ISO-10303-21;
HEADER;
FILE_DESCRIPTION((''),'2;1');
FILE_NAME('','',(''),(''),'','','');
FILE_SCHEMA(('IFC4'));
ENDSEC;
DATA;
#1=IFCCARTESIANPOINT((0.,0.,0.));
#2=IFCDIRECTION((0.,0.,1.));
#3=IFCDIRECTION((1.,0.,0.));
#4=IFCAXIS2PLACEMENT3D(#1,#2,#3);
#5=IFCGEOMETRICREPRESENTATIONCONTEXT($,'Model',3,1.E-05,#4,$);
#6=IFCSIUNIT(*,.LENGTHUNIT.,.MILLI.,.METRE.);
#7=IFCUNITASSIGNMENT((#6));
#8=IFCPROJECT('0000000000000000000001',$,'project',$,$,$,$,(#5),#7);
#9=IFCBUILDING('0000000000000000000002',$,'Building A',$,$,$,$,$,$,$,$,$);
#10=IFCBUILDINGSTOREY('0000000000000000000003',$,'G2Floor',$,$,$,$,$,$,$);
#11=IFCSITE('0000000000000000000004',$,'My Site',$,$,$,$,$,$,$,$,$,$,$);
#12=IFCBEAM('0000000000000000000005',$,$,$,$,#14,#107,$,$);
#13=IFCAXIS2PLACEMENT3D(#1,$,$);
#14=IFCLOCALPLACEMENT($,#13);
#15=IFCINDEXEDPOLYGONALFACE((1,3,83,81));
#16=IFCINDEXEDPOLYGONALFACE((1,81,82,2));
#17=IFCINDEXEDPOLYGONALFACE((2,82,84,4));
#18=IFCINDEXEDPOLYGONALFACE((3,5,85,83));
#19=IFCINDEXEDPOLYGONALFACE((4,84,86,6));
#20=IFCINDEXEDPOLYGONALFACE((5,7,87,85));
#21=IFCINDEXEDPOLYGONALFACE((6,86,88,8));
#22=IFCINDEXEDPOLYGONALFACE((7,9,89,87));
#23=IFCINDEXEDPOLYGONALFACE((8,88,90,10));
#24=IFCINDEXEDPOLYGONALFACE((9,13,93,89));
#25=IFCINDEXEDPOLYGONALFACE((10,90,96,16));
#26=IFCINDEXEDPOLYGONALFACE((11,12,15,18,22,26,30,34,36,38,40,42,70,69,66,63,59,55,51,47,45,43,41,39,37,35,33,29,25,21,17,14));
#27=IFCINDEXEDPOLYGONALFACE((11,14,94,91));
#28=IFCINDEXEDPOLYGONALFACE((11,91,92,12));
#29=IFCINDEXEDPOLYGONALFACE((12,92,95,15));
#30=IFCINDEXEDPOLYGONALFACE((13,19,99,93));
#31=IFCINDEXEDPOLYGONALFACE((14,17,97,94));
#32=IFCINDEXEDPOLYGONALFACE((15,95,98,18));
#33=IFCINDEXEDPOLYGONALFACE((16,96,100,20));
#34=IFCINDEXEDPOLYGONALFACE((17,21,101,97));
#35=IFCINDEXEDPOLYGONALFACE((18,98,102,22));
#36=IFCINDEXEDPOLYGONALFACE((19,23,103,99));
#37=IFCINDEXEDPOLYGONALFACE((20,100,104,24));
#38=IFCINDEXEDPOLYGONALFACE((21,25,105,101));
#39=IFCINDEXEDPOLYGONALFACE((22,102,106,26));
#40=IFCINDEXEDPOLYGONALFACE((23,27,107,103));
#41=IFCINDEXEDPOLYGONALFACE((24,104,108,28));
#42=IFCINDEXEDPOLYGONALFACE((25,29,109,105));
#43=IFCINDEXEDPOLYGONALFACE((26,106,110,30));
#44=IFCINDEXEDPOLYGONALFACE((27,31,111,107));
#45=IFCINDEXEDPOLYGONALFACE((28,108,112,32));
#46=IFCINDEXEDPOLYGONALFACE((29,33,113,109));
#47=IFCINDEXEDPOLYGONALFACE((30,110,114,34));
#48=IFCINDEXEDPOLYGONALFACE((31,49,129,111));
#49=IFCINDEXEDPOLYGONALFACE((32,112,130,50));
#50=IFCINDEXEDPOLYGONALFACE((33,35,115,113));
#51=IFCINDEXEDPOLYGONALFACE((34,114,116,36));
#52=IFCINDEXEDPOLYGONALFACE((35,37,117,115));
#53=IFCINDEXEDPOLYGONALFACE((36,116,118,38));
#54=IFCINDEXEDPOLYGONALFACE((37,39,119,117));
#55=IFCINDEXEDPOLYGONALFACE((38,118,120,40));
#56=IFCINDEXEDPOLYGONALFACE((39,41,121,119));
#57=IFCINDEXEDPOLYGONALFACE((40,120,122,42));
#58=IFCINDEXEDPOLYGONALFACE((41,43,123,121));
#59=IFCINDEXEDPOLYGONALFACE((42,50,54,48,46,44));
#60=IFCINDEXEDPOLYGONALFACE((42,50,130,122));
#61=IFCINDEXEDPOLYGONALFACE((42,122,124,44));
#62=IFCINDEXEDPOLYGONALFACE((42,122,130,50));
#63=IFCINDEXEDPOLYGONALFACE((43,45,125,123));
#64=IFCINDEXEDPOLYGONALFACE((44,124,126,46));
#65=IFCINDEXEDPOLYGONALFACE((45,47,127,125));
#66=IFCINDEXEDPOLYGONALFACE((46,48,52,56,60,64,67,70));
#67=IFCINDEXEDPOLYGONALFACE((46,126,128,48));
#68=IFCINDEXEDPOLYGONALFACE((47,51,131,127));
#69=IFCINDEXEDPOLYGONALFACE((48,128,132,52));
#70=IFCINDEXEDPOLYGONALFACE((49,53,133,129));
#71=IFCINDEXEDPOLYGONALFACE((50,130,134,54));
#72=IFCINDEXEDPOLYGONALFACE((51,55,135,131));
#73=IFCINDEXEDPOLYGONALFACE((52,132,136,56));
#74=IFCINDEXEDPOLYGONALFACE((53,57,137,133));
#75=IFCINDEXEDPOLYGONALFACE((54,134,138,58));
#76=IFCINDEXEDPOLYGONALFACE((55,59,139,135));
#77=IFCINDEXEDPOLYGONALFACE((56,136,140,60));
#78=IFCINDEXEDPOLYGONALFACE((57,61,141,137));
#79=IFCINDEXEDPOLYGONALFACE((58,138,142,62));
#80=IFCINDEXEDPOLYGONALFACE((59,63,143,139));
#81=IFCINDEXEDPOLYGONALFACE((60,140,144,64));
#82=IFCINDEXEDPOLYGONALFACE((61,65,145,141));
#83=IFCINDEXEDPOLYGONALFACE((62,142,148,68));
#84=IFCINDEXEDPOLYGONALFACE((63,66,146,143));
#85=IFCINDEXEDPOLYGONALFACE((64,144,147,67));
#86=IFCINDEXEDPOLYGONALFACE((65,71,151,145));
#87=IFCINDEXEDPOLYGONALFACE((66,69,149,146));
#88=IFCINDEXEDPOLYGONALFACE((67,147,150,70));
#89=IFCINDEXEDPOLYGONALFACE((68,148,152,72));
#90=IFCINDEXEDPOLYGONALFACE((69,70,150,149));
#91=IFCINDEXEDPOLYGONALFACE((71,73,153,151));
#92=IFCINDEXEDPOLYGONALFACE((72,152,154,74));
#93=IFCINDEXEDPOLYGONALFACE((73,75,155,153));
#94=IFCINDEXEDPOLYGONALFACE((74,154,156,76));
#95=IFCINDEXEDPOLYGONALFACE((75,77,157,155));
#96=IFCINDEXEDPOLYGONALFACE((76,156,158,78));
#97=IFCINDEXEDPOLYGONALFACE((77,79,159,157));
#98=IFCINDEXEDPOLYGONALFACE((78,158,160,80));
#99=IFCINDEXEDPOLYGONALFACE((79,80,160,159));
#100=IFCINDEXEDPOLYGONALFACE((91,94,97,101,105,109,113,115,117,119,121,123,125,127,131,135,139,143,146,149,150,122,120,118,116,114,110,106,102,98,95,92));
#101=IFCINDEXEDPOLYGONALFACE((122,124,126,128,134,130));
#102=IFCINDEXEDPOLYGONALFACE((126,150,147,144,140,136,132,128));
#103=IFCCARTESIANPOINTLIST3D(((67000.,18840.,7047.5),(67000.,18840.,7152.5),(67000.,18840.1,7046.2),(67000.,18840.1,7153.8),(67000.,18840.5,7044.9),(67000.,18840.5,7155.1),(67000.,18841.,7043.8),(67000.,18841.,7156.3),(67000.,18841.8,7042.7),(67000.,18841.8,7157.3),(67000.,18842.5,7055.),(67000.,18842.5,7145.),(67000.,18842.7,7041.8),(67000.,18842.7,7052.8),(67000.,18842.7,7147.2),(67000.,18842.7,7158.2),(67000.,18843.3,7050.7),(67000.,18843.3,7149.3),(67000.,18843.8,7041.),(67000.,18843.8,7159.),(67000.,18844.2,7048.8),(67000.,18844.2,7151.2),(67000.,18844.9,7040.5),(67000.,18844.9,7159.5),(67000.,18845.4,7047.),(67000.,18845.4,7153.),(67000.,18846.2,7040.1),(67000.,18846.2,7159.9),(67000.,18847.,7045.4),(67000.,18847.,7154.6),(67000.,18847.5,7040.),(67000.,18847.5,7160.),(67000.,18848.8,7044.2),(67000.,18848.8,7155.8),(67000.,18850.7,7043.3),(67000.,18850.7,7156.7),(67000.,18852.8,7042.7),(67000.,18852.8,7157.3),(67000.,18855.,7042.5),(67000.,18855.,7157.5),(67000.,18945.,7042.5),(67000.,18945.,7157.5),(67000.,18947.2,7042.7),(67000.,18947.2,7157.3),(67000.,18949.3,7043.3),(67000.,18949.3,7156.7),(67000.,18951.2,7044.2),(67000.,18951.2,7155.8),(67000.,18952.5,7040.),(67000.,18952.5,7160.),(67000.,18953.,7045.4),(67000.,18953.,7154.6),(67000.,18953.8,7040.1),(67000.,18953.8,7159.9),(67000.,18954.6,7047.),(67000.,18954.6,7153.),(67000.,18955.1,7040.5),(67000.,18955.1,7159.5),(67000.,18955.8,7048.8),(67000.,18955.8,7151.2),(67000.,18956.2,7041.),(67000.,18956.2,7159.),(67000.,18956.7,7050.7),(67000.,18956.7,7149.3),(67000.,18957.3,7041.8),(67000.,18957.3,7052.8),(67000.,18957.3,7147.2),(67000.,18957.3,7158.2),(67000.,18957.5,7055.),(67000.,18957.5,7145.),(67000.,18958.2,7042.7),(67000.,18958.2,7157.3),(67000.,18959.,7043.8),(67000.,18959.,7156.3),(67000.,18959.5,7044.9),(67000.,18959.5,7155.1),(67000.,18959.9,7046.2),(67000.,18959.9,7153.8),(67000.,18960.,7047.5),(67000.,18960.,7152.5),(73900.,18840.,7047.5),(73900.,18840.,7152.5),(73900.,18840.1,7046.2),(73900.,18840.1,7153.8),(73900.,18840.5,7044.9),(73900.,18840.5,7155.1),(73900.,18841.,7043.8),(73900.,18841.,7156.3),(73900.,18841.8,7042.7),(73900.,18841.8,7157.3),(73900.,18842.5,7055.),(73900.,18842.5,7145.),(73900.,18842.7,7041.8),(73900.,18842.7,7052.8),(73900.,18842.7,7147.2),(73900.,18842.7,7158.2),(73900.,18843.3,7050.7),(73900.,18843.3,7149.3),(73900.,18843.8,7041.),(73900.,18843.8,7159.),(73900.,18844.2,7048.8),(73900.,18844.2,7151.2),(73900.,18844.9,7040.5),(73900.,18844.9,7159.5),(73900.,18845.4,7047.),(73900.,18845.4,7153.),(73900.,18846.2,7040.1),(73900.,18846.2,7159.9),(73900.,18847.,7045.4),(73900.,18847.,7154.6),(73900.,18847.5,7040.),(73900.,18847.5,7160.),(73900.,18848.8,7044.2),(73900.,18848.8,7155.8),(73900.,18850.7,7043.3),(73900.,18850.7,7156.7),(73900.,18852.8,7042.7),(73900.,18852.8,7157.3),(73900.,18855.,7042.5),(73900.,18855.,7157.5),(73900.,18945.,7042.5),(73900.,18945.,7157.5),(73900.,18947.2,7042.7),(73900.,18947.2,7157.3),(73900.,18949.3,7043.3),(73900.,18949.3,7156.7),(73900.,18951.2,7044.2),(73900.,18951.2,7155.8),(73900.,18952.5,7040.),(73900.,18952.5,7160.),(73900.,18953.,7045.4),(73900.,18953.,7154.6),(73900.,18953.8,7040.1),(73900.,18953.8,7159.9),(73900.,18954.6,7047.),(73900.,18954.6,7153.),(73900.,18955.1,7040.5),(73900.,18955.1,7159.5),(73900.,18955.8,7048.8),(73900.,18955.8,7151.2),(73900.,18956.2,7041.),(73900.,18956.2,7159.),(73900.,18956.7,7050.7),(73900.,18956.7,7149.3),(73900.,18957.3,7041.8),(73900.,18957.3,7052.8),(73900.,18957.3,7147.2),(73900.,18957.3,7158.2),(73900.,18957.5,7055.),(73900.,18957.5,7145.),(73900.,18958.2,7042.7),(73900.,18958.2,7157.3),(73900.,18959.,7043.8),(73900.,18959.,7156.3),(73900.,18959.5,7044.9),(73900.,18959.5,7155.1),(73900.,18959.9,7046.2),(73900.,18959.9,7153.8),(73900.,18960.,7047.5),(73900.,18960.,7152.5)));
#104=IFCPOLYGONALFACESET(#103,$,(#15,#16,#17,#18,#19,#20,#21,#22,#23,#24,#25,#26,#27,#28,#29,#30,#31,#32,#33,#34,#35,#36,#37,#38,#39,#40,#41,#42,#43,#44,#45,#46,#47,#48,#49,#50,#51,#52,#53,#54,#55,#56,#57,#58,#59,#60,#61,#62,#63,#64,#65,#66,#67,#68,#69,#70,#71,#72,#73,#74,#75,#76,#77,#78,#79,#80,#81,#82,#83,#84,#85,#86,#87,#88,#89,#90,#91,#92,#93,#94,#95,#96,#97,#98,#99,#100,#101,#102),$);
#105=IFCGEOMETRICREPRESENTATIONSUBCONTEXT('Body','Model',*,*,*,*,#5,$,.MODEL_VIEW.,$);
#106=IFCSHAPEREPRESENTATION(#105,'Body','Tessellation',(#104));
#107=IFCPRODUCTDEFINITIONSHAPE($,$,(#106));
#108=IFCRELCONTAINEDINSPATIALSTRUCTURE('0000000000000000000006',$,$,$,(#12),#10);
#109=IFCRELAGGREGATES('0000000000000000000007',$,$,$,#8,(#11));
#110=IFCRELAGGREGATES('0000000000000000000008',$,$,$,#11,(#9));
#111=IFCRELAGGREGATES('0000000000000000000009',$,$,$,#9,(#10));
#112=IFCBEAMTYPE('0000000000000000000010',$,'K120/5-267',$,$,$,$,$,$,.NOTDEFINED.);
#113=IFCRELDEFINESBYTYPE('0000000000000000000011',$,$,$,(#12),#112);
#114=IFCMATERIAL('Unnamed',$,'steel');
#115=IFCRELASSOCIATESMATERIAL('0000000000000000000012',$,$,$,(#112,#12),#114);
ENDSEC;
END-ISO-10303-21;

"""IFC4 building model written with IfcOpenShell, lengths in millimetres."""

from ifc_helpers import new_model, si_unit, frame, origin_with_axes, place, context, subcontext, project, spatial, polyline, outline, extrude, material, material_profile, profile_set, profile_usage, type_object, element, save


model = new_model("IFC4")

# Units and contexts
model_context = context("Model", 3, precision=1e-05, world=origin_with_axes())
body_context = subcontext(model_context, "Body", "Model", "MODEL_VIEW")
ifc_project = project(units=[si_unit("LENGTHUNIT", "METRE", prefix="MILLI")], contexts=[model_context])

# Site, building, storey
site = spatial("IfcSite", under=ifc_project, Name="My Site")
building = spatial("IfcBuilding", under=site, Name="Building A")
storey = spatial("IfcBuildingStorey", under=building, Name="G2Floor")

# Beam
ifc_material_1 = material(Name="Unnamed", Category="steel")
ifc_material_profile_1 = material_profile(ifc_material_1, outline(polyline([(-52.5, -60.0), (52.5, -60.0), (52.5, -60.0), (53.8, -59.9), (53.8, -59.9), (55.1, -59.5), (55.1, -59.5), (56.2, -59.0), (56.2, -59.0), (57.3, -58.2), (57.3, -58.2), (58.2, -57.3), (58.2, -57.3), (59.0, -56.2), (59.0, -56.2), (59.5, -55.1), (59.5, -55.1), (59.9, -53.8), (59.9, -53.8), (60.0, -52.5), (60.0, -52.5), (60.0, 52.5), (60.0, 52.5), (59.9, 53.8), (59.9, 53.8), (59.5, 55.1), (59.5, 55.1), (59.0, 56.2), (59.0, 56.2), (58.2, 57.3), (58.2, 57.3), (57.3, 58.2), (57.3, 58.2), (56.2, 59.0), (56.2, 59.0), (55.1, 59.5), (55.1, 59.5), (53.8, 59.9), (53.8, 59.9), (52.5, 60.0), (52.5, 60.0), (-52.5, 60.0), (-52.5, 60.0), (-53.8, 59.9), (-53.8, 59.9), (-55.1, 59.5), (-55.1, 59.5), (-56.2, 59.0), (-56.2, 59.0), (-57.3, 58.2), (-57.3, 58.2), (-58.2, 57.3), (-58.2, 57.3), (-59.0, 56.2), (-59.0, 56.2), (-59.5, 55.1), (-59.5, 55.1), (-59.9, 53.8), (-59.9, 53.8), (-60.0, 52.5), (-60.0, 52.5), (-60.0, -52.5), (-60.0, -52.5), (-59.9, -53.8), (-59.9, -53.8), (-59.5, -55.1), (-59.5, -55.1), (-59.0, -56.2), (-59.0, -56.2), (-58.2, -57.3), (-58.2, -57.3), (-57.3, -58.2), (-57.3, -58.2), (-56.2, -59.0), (-56.2, -59.0), (-55.1, -59.5), (-55.1, -59.5), (-53.8, -59.9), (-53.8, -59.9), (-52.5, -60.0), (-52.5, -60.0), (-45.0, -57.5), (-45.0, -57.5), (45.0, -57.5), (45.0, -57.5), (47.2, -57.3), (47.2, -57.3), (49.3, -56.7), (49.3, -56.7), (51.2, -55.8), (51.2, -55.8), (53.0, -54.6), (53.0, -54.6), (54.6, -53.0), (54.6, -53.0), (55.8, -51.2), (55.8, -51.2), (56.7, -49.3), (56.7, -49.3), (57.3, -47.2), (57.3, -47.2), (57.5, -45.0), (57.5, -45.0), (57.5, 45.0), (57.5, 45.0), (57.3, 47.2), (57.3, 47.2), (56.7, 49.3), (56.7, 49.3), (55.8, 51.2), (55.8, 51.2), (54.6, 53.0), (54.6, 53.0), (53.0, 54.6), (53.0, 54.6), (51.2, 55.8), (51.2, 55.8), (49.3, 56.7), (49.3, 56.7), (47.2, 57.3), (47.2, 57.3), (45.0, 57.5), (45.0, 57.5), (-45.0, 57.5), (-45.0, 57.5), (-47.2, 57.3), (-47.2, 57.3), (-49.3, 56.7), (-49.3, 56.7), (-51.2, 55.8), (-51.2, 55.8), (-53.0, 54.6), (-53.0, 54.6), (-54.6, 53.0), (-54.6, 53.0), (-55.8, 51.2), (-55.8, 51.2), (-56.7, 49.3), (-56.7, 49.3), (-57.3, 47.2), (-57.3, 47.2), (-57.5, 45.0), (-57.5, 45.0), (-57.5, -45.0), (-57.5, -45.0), (-57.3, -47.2), (-57.3, -47.2), (-56.7, -49.3), (-56.7, -49.3), (-55.8, -51.2), (-55.8, -51.2), (-54.6, -53.0), (-54.6, -53.0), (-53.0, -54.6), (-53.0, -54.6), (-51.2, -55.8), (-51.2, -55.8), (-49.3, -56.7), (-49.3, -56.7), (-47.2, -57.3), (-47.2, -57.3), (-45.0, -57.5), (-45.0, -57.5), (-52.5, -60.0)])))
ifc_profile_set_1 = profile_set([ifc_material_profile_1], Name="K120/5-267")
ifc_profile_usage_1 = profile_usage(ifc_profile_set_1)
beam_type_1 = type_object("IfcBeamType", Name="K120/5-267", PredefinedType="NOTDEFINED", material=ifc_profile_set_1)
beam_1_placement = place(None, frame((67000.0, 18900.0, 7100.0), z_axis=(1.0, 0.0, 0.0), x_axis=(0.0, -1.0, 0.0)))
element("IfcBeam", 1, at=beam_1_placement, inside=storey, type_object=beam_type_1, material=ifc_profile_usage_1, context=body_context, shape_type="SweptSolid", body=[
    extrude(outline(polyline([(-52.5, -60.0), (52.5, -60.0), (52.5, -60.0), (53.8, -59.9), (53.8, -59.9), (55.1, -59.5), (55.1, -59.5), (56.2, -59.0), (56.2, -59.0), (57.3, -58.2), (57.3, -58.2), (58.2, -57.3), (58.2, -57.3), (59.0, -56.2), (59.0, -56.2), (59.5, -55.1), (59.5, -55.1), (59.9, -53.8), (59.9, -53.8), (60.0, -52.5), (60.0, -52.5), (60.0, 52.5), (60.0, 52.5), (59.9, 53.8), (59.9, 53.8), (59.5, 55.1), (59.5, 55.1), (59.0, 56.2), (59.0, 56.2), (58.2, 57.3), (58.2, 57.3), (57.3, 58.2), (57.3, 58.2), (56.2, 59.0), (56.2, 59.0), (55.1, 59.5), (55.1, 59.5), (53.8, 59.9), (53.8, 59.9), (52.5, 60.0), (52.5, 60.0), (-52.5, 60.0), (-52.5, 60.0), (-53.8, 59.9), (-53.8, 59.9), (-55.1, 59.5), (-55.1, 59.5), (-56.2, 59.0), (-56.2, 59.0), (-57.3, 58.2), (-57.3, 58.2), (-58.2, 57.3), (-58.2, 57.3), (-59.0, 56.2), (-59.0, 56.2), (-59.5, 55.1), (-59.5, 55.1), (-59.9, 53.8), (-59.9, 53.8), (-60.0, 52.5), (-60.0, 52.5), (-60.0, -52.5), (-60.0, -52.5), (-59.9, -53.8), (-59.9, -53.8), (-59.5, -55.1), (-59.5, -55.1), (-59.0, -56.2), (-59.0, -56.2), (-58.2, -57.3), (-58.2, -57.3), (-57.3, -58.2), (-57.3, -58.2), (-56.2, -59.0), (-56.2, -59.0), (-55.1, -59.5), (-55.1, -59.5), (-53.8, -59.9), (-53.8, -59.9), (-52.5, -60.0), (-52.5, -60.0), (-45.0, -57.5), (-45.0, -57.5), (45.0, -57.5), (45.0, -57.5), (47.2, -57.3), (47.2, -57.3), (49.3, -56.7), (49.3, -56.7), (51.2, -55.8), (51.2, -55.8), (53.0, -54.6), (53.0, -54.6), (54.6, -53.0), (54.6, -53.0), (55.8, -51.2), (55.8, -51.2), (56.7, -49.3), (56.7, -49.3), (57.3, -47.2), (57.3, -47.2), (57.5, -45.0), (57.5, -45.0), (57.5, 45.0), (57.5, 45.0), (57.3, 47.2), (57.3, 47.2), (56.7, 49.3), (56.7, 49.3), (55.8, 51.2), (55.8, 51.2), (54.6, 53.0), (54.6, 53.0), (53.0, 54.6), (53.0, 54.6), (51.2, 55.8), (51.2, 55.8), (49.3, 56.7), (49.3, 56.7), (47.2, 57.3), (47.2, 57.3), (45.0, 57.5), (45.0, 57.5), (-45.0, 57.5), (-45.0, 57.5), (-47.2, 57.3), (-47.2, 57.3), (-49.3, 56.7), (-49.3, 56.7), (-51.2, 55.8), (-51.2, 55.8), (-53.0, 54.6), (-53.0, 54.6), (-54.6, 53.0), (-54.6, 53.0), (-55.8, 51.2), (-55.8, 51.2), (-56.7, 49.3), (-56.7, 49.3), (-57.3, 47.2), (-57.3, 47.2), (-57.5, 45.0), (-57.5, 45.0), (-57.5, -45.0), (-57.5, -45.0), (-57.3, -47.2), (-57.3, -47.2), (-56.7, -49.3), (-56.7, -49.3), (-55.8, -51.2), (-55.8, -51.2), (-54.6, -53.0), (-54.6, -53.0), (-53.0, -54.6), (-53.0, -54.6), (-51.2, -55.8), (-51.2, -55.8), (-49.3, -56.7), (-49.3, -56.7), (-47.2, -57.3), (-47.2, -57.3), (-45.0, -57.5), (-45.0, -57.5), (-52.5, -60.0)])), origin_with_axes(), (0.0, 0.0, 1.0), 6900.0),
])

save(model, "model.ifc")
